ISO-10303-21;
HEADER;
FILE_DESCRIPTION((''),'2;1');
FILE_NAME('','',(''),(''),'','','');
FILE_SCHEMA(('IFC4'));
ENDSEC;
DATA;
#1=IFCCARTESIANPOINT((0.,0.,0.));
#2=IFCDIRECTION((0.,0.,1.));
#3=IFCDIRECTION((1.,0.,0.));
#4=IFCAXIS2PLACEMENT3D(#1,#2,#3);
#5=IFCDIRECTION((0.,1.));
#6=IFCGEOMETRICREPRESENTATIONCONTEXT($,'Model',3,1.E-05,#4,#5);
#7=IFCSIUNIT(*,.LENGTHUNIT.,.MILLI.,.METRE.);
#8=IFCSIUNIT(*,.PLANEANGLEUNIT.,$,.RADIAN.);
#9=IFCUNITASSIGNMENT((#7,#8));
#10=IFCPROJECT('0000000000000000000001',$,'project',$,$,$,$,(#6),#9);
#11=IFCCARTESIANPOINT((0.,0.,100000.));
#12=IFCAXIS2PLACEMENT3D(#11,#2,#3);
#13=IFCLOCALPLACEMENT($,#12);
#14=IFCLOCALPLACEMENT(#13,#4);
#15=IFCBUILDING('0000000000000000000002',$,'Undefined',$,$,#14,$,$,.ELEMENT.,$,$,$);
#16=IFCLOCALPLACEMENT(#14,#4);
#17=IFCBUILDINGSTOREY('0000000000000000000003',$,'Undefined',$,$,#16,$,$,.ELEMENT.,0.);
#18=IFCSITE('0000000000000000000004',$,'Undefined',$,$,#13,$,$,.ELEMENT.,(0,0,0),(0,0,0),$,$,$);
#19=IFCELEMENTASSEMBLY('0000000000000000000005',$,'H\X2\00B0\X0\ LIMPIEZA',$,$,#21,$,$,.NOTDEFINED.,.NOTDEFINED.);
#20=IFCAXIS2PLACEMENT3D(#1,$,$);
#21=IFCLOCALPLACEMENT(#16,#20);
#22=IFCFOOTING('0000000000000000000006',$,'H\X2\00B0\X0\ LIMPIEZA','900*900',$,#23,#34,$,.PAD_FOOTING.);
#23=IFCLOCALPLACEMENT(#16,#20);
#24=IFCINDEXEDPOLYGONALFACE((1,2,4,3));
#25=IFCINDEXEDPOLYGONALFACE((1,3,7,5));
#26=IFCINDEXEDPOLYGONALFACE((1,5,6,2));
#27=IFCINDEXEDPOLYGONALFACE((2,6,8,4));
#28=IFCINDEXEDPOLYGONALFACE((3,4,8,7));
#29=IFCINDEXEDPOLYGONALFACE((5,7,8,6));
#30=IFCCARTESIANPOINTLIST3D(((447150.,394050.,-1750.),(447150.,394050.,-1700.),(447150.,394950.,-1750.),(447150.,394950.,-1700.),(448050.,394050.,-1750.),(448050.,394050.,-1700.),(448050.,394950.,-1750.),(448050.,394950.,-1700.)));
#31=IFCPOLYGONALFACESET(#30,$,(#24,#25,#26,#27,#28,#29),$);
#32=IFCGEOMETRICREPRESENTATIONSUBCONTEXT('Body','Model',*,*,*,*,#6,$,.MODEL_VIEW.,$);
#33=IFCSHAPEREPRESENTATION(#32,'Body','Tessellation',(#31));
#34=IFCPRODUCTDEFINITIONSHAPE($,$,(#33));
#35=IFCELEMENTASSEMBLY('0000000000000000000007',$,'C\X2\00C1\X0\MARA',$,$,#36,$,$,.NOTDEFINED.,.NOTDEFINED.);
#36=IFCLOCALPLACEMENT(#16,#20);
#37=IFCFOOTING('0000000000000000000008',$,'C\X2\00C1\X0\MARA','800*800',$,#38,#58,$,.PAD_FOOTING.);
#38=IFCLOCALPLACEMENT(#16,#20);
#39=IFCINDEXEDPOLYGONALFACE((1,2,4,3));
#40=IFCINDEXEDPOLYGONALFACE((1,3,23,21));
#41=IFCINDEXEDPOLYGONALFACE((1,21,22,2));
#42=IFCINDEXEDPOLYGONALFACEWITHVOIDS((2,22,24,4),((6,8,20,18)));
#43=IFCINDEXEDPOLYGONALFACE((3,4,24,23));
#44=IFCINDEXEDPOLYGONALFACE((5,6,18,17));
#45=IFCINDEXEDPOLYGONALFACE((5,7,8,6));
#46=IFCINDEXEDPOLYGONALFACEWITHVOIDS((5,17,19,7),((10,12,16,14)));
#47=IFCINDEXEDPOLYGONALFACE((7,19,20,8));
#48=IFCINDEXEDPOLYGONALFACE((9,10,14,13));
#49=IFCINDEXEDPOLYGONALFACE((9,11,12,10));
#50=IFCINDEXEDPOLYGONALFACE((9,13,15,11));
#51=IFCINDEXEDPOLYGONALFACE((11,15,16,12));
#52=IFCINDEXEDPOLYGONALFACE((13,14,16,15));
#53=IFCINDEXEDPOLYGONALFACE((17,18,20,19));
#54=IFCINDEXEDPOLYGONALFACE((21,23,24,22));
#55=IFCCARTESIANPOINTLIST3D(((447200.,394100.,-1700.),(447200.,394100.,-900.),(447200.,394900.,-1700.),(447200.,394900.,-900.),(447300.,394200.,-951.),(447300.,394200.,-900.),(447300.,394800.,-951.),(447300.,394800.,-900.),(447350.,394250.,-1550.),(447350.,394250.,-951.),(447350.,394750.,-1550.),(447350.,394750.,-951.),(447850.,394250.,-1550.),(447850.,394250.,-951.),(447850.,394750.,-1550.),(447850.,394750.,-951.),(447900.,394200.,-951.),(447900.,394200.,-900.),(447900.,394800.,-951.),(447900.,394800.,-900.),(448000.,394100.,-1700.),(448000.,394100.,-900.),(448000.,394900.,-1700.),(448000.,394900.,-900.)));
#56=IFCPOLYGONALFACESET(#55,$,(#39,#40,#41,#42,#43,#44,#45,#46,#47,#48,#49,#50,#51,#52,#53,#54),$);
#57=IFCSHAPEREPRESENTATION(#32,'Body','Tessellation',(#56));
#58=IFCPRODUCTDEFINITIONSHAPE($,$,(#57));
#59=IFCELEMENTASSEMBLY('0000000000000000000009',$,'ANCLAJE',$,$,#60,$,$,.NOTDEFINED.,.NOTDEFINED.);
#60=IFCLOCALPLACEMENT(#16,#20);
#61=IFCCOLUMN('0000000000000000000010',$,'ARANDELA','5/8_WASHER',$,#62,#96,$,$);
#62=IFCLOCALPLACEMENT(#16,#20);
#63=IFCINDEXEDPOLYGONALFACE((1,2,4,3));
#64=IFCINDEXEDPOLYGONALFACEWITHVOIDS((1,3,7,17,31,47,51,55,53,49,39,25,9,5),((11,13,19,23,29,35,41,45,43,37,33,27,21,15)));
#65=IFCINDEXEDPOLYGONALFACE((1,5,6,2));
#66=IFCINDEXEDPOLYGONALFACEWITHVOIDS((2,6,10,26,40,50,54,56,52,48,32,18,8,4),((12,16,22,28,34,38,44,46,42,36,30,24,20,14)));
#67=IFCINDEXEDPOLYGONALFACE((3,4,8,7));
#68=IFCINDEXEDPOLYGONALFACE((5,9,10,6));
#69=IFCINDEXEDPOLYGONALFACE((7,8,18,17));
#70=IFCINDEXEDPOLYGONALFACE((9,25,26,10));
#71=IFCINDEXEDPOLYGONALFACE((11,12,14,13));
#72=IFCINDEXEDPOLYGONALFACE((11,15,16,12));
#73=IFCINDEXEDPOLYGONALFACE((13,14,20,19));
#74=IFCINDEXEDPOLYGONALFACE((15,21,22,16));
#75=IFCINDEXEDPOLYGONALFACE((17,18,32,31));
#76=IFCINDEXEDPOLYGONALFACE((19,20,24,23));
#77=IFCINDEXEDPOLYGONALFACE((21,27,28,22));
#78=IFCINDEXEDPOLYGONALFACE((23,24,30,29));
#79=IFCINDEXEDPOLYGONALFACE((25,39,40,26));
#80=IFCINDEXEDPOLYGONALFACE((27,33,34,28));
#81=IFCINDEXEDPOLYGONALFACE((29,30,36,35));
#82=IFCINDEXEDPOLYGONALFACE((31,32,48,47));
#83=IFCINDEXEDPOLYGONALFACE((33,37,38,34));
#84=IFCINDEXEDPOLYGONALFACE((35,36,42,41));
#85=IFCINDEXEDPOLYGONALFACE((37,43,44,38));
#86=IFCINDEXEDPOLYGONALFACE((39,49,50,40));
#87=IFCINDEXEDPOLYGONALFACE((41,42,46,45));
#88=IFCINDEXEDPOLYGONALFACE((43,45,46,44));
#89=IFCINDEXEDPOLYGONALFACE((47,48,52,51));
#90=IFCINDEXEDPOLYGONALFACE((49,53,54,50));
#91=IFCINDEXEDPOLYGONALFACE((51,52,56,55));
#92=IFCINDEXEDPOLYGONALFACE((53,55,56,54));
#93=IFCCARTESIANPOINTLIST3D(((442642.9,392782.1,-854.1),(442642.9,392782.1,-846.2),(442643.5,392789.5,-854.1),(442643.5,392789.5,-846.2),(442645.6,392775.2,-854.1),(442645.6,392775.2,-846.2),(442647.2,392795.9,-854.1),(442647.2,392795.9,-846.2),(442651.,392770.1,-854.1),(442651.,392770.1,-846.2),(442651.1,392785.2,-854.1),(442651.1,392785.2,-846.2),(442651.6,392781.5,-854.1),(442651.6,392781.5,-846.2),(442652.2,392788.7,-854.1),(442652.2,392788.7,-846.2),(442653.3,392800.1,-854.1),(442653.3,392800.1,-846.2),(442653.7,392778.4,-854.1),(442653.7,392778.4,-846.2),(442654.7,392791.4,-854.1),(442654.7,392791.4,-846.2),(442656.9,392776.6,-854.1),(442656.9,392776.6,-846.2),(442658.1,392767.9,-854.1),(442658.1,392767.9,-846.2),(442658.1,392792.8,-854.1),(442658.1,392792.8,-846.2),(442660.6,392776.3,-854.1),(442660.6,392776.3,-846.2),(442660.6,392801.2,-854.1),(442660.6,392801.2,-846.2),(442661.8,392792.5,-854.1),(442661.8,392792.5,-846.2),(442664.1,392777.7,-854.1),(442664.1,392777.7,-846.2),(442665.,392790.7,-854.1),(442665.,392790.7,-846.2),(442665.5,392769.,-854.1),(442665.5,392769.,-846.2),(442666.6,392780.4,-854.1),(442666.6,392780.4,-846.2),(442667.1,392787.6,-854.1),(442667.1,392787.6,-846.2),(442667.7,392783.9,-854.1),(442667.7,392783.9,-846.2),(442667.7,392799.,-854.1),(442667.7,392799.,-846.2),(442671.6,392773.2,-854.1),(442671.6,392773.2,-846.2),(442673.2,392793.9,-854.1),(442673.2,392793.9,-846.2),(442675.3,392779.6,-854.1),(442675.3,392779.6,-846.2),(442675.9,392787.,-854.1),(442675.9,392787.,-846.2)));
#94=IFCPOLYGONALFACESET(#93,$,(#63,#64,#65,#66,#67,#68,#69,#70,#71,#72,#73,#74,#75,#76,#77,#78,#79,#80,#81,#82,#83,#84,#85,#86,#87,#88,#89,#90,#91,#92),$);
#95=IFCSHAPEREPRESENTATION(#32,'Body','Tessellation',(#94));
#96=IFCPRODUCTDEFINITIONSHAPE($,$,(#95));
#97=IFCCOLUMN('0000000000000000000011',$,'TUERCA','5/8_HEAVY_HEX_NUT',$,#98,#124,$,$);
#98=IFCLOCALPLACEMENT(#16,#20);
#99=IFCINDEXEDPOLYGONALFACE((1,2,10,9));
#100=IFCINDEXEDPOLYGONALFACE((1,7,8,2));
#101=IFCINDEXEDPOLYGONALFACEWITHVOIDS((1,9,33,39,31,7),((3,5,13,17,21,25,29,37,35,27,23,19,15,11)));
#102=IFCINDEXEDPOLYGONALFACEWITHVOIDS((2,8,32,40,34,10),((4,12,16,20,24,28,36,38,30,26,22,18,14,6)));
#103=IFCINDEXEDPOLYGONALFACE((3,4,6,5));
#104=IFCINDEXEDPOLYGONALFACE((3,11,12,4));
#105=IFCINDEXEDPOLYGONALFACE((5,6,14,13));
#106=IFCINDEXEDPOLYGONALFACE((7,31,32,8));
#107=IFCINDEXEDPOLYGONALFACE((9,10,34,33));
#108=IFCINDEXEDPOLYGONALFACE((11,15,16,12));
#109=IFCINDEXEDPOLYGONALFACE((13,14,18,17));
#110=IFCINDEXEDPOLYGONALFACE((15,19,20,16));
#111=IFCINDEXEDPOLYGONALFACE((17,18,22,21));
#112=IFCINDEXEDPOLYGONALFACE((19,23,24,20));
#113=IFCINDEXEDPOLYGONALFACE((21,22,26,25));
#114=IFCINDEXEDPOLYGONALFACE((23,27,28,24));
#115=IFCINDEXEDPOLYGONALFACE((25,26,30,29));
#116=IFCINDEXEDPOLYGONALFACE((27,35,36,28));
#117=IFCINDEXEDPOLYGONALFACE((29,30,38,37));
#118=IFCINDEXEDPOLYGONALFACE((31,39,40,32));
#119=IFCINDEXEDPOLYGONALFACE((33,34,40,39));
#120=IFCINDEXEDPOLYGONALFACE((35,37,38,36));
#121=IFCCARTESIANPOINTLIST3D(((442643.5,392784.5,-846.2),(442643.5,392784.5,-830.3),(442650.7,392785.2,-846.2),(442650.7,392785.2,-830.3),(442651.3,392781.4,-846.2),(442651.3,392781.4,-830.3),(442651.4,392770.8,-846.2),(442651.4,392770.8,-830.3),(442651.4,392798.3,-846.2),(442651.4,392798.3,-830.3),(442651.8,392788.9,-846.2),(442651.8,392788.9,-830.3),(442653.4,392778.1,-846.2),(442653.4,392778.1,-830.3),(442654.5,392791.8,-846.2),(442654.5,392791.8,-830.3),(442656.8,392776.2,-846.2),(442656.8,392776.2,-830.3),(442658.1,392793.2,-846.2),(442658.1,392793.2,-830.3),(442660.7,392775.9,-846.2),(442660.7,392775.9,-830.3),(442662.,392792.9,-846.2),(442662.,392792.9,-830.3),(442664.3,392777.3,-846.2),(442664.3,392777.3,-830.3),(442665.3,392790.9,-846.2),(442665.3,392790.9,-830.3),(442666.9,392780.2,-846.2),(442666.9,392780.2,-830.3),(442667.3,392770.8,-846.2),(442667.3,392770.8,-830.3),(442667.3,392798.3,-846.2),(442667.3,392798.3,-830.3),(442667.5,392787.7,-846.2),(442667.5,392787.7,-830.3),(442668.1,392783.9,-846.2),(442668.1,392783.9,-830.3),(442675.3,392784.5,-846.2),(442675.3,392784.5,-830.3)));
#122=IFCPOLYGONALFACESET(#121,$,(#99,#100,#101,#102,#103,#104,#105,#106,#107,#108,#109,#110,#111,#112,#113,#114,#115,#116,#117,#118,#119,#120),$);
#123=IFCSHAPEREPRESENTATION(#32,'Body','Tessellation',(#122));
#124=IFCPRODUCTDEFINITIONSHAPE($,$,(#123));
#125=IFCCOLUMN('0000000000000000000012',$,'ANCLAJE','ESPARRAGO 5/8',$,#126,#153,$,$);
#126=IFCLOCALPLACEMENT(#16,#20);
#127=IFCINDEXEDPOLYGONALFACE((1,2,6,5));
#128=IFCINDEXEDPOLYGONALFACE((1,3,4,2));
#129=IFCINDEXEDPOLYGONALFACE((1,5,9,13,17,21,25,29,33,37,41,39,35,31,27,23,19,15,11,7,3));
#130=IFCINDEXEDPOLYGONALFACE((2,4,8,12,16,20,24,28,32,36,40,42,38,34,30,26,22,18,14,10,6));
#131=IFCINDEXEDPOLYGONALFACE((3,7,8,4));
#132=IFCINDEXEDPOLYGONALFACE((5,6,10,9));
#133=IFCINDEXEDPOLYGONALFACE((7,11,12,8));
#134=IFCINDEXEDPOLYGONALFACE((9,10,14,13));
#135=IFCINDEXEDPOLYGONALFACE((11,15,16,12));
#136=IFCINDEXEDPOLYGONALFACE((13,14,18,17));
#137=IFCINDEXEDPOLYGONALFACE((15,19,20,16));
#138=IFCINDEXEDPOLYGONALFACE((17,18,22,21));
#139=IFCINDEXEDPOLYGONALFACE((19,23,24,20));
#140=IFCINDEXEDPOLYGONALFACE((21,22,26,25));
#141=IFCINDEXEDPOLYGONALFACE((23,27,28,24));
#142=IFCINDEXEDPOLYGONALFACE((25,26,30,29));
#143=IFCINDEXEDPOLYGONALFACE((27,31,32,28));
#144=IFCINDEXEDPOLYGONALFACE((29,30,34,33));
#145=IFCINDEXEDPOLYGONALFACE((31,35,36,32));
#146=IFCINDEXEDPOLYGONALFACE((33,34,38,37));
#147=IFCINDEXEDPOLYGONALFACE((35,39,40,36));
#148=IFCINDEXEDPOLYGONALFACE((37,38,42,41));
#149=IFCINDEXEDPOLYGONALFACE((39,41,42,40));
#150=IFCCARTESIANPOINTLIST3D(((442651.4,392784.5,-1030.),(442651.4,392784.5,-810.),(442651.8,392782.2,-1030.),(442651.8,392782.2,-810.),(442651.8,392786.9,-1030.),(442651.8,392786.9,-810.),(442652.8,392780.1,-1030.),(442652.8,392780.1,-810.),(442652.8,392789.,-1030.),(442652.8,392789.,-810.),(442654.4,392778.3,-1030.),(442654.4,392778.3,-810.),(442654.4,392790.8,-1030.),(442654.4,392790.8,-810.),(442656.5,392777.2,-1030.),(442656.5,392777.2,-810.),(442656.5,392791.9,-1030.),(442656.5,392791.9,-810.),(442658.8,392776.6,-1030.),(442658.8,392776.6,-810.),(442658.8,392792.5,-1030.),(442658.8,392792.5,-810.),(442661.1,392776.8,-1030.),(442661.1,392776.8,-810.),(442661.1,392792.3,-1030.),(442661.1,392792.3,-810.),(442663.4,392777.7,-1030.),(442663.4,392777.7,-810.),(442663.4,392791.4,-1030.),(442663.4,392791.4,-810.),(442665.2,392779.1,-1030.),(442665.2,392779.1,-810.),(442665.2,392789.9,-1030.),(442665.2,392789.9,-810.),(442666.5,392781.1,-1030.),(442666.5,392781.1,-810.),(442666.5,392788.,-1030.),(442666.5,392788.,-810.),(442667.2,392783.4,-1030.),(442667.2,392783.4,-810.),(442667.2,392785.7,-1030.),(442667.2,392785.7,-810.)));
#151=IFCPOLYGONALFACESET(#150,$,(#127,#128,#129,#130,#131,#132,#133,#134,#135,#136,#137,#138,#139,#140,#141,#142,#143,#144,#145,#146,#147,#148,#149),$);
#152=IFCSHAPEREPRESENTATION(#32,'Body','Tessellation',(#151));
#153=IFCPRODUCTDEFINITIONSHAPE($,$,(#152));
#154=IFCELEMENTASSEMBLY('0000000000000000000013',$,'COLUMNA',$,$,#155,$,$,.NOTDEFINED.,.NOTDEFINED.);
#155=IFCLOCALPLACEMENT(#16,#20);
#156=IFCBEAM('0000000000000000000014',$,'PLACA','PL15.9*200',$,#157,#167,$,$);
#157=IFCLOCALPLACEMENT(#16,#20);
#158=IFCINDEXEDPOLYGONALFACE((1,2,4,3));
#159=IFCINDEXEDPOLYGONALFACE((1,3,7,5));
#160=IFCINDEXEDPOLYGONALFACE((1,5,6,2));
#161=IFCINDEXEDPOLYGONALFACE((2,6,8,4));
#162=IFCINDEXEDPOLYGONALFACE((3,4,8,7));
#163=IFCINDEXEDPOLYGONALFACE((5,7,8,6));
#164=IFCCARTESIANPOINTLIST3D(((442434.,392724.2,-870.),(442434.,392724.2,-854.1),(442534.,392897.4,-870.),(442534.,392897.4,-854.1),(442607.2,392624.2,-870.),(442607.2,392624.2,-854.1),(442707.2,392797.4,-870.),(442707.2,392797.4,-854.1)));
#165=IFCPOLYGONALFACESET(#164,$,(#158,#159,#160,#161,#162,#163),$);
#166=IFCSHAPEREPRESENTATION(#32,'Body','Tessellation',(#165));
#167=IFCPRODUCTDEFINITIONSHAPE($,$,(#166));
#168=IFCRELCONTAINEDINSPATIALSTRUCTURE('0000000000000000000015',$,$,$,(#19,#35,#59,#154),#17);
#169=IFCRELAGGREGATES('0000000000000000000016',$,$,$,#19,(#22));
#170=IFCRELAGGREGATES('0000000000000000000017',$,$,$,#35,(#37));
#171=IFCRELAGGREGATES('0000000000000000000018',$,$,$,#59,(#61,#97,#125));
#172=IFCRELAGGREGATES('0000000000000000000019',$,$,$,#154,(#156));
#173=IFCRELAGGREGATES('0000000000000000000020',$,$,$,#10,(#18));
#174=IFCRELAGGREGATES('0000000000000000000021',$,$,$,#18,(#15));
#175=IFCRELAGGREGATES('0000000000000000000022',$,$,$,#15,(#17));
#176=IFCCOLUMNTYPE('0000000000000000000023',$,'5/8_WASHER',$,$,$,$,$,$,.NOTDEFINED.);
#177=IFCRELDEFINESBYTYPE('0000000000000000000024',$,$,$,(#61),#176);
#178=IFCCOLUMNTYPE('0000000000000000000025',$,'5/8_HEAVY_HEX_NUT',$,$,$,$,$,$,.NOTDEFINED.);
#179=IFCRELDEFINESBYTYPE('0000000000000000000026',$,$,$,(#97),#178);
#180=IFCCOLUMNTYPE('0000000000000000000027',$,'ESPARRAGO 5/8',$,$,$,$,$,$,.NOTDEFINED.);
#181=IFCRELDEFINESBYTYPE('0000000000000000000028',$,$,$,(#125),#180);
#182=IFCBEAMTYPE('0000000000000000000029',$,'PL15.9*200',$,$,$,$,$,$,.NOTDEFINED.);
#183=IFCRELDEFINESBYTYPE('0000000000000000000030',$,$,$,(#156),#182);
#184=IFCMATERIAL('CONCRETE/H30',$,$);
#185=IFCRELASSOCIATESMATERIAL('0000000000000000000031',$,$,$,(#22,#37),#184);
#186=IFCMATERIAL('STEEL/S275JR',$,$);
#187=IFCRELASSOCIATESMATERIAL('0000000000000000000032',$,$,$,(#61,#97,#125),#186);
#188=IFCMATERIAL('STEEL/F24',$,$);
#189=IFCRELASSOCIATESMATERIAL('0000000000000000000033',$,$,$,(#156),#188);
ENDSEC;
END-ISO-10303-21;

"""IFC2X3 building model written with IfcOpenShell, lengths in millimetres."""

from ifc_helpers import new_model, si_unit, direction, frame, origin_with_axes, origin_2d_with_axis, place, context, subcontext, project, spatial, polyline, rectangle, circle, outline, extrude, boolean, material, type_object, element, aggregate, save


model = new_model("IFC2X3")

# Units and contexts
model_context = context("Model", 3, precision=1e-05, world=origin_with_axes(), true_north=direction((0.0, 1.0)))
body_context = subcontext(model_context, "Body", "Model", "MODEL_VIEW")
ifc_project = project(units=[si_unit("LENGTHUNIT", "METRE", prefix="MILLI"), si_unit("PLANEANGLEUNIT", "RADIAN")], contexts=[model_context])

# Site, building, storey
site_placement = place(None, frame((0.0, 0.0, 100000.0), z_axis=(0.0, 0.0, 1.0), x_axis=(1.0, 0.0, 0.0)))
site = spatial("IfcSite", under=ifc_project, at=site_placement, Name="Undefined", CompositionType="ELEMENT", RefLatitude=(0, 0, 0), RefLongitude=(0, 0, 0))
building_placement = place(site_placement, origin_with_axes())
building = spatial("IfcBuilding", under=site, at=building_placement, Name="Undefined", CompositionType="ELEMENT")
storey_placement = place(building_placement, origin_with_axes())
storey = spatial("IfcBuildingStorey", under=building, at=storey_placement, Name="Undefined", CompositionType="ELEMENT", Elevation=0.0)

# Element assemblies, footings
assembly_1_placement = place(storey_placement, origin_with_axes())
assembly_1 = element("IfcElementAssembly", 1, at=assembly_1_placement, inside=storey, Name="H° LIMPIEZA", AssemblyPlace="NOTDEFINED", PredefinedType="NOTDEFINED")
ifc_material_1 = material(Name="CONCRETE/H30")
footing_1_placement = place(assembly_1_placement, frame((447600.0, 394500.0, -1750.0), z_axis=(0.0, -1.0, 0.0), x_axis=(0.0, 0.0, 1.0)))
footing_1 = element("IfcFooting", 2, at=footing_1_placement, material=ifc_material_1, Name="H° LIMPIEZA", Description="900*900", PredefinedType="PAD_FOOTING", context=body_context, shape_type="SweptSolid", body=[
    extrude(rectangle(XDim=900.0, YDim=900.0, at=origin_2d_with_axis()), frame((50.0, 0.0, 0.0), z_axis=(-1.0, 0.0, 0.0), x_axis=(0.0, -1.0, 0.0)), (0.0, 0.0, 1.0), 50.0),
])
aggregate(assembly_1, [footing_1])
assembly_2_placement = place(storey_placement, origin_with_axes())
assembly_2 = element("IfcElementAssembly", 3, at=assembly_2_placement, inside=storey, Name="CÁMARA", AssemblyPlace="NOTDEFINED", PredefinedType="NOTDEFINED")
footing_2_placement = place(assembly_2_placement, frame((447600.0, 394500.0, -1700.0), z_axis=(0.0, -1.0, 0.0), x_axis=(0.0, 0.0, 1.0)))
footing_2 = element("IfcFooting", 4, at=footing_2_placement, material=ifc_material_1, Name="CÁMARA", Description="800*800", PredefinedType="PAD_FOOTING", context=body_context, shape_type="CSG", body=[
    boolean("DIFFERENCE", boolean("DIFFERENCE", extrude(rectangle(XDim=800.0, YDim=800.0, at=origin_2d_with_axis()), frame((800.0, 0.0, 0.0), z_axis=(-1.0, 0.0, 0.0), x_axis=(0.0, -1.0, 0.0)), (0.0, 0.0, 1.0), 800.0), extrude(rectangle(XDim=600.0, YDim=600.0, at=origin_2d_with_axis()), frame((800.0, 0.0, 0.0), z_axis=(-1.0, 0.0, 0.0), x_axis=(0.0, -1.0, 0.0)), (0.0, 0.0, 1.0), 51.0)), extrude(rectangle(XDim=500.0, YDim=500.0, at=origin_2d_with_axis()), frame((750.0, 0.0, 0.0), z_axis=(-1.0, 0.0, 0.0), x_axis=(0.0, -1.0, 0.0)), (0.0, 0.0, 1.0), 600.0)),
])
aggregate(assembly_2, [footing_2])

# Element assembly, columns
assembly_3_placement = place(storey_placement, origin_with_axes())
assembly_3 = element("IfcElementAssembly", 5, at=assembly_3_placement, inside=storey, Name="ANCLAJE", AssemblyPlace="NOTDEFINED", PredefinedType="NOTDEFINED")
ifc_material_2 = material(Name="STEEL/S275JR")
column_type_1 = type_object("IfcColumnType", Name="5/8_WASHER", PredefinedType="NOTDEFINED")
column_1_placement = place(assembly_3_placement, frame((442659.4, 392784.5, -846.2), z_axis=(0.0, 0.0, -1.0), x_axis=(-0.866025, 0.5, 0.0)))
column_1 = element("IfcColumn", 6, at=column_1_placement, type_object=column_type_1, material=ifc_material_2, Name="ARANDELA", Description="5/8_WASHER", context=body_context, shape_type="SweptSolid", body=[
    extrude(outline(polyline([(10.4, 13.0), (15.0, 7.2), (16.7, 0.0), (15.0, -7.2), (10.4, -13.0), (3.7, -16.3), (-3.7, -16.3), (-10.4, -13.0), (-15.0, -7.2), (-16.7, 0.0), (-15.0, 7.2), (-10.4, 13.0), (-3.7, 16.3), (3.7, 16.3), (10.4, 13.0)]), holes=[polyline([(6.5, -5.2), (8.1, -1.9), (8.1, 1.9), (6.5, 5.2), (3.6, 7.5), (0.0, 8.3), (-3.6, 7.5), (-6.5, 5.2), (-8.1, 1.9), (-8.1, -1.9), (-6.5, -5.2), (-3.6, -7.5), (0.0, -8.3), (3.6, -7.5), (6.5, -5.2)])]), frame((0.0, 0.0, 7.9), z_axis=(0.0, 0.0, -1.0), x_axis=(0.0, 1.0, 0.0)), (0.0, 0.0, 1.0), 7.9),
])
column_type_2 = type_object("IfcColumnType", Name="5/8_HEAVY_HEX_NUT", PredefinedType="NOTDEFINED")
column_2_placement = place(assembly_3_placement, frame((442659.4, 392784.5, -830.3), z_axis=(0.0, 0.0, -1.0), x_axis=(-0.866025, 0.5, 0.0)))
column_2 = element("IfcColumn", 7, at=column_2_placement, type_object=column_type_2, material=ifc_material_2, Name="TUERCA", Description="5/8_HEAVY_HEX_NUT", context=body_context, shape_type="SweptSolid", body=[
    extrude(outline(polyline([(-7.9, -13.7), (-15.9, 0.0), (-7.9, 13.7), (7.9, 13.7), (15.9, 0.0), (7.9, -13.7), (-7.9, -13.7)]), holes=[polyline([(3.8, 7.9), (0.0, 8.7), (-3.8, 7.9), (-6.8, 5.4), (-8.5, 1.9), (-8.5, -1.9), (-6.8, -5.4), (-3.8, -7.9), (0.0, -8.7), (3.8, -7.9), (6.8, -5.4), (8.5, -1.9), (8.5, 1.9), (6.8, 5.4), (3.8, 7.9)])]), frame((0.0, 0.0, 15.9), z_axis=(0.0, 0.0, -1.0), x_axis=(0.0, 1.0, 0.0)), (0.0, 0.0, 1.0), 15.9),
])
column_type_3 = type_object("IfcColumnType", Name="ESPARRAGO 5/8", PredefinedType="NOTDEFINED")
column_3_placement = place(assembly_3_placement, frame((442659.4, 392784.5, -810.0), z_axis=(0.0, 0.0, -1.0), x_axis=(-0.866025, 0.5, 0.0)))
column_3 = element("IfcColumn", 8, at=column_3_placement, type_object=column_type_3, material=ifc_material_2, Name="ANCLAJE", Description="ESPARRAGO 5/8", context=body_context, shape_type="SweptSolid", body=[
    extrude(circle(Radius=7.9, at=origin_2d_with_axis()), frame((0.0, 0.0, 220.0), z_axis=(0.0, 0.0, -1.0), x_axis=(0.0, 1.0, 0.0)), (0.0, 0.0, 1.0), 220.0),
])
aggregate(assembly_3, [column_1, column_2, column_3])

# Element assembly, beam
assembly_4_placement = place(storey_placement, origin_with_axes())
assembly_4 = element("IfcElementAssembly", 9, at=assembly_4_placement, inside=storey, Name="COLUMNA", AssemblyPlace="NOTDEFINED", PredefinedType="NOTDEFINED")
ifc_material_3 = material(Name="STEEL/F24")
beam_type = type_object("IfcBeamType", Name="PL15.9*200", PredefinedType="NOTDEFINED")
beam_placement = place(assembly_4_placement, frame((442657.2, 392710.8, -862.1), z_axis=(-0.5, -0.866025, 0.0), x_axis=(-0.866025, 0.5, 0.0)))
beam = element("IfcBeam", 10, at=beam_placement, type_object=beam_type, material=ifc_material_3, Name="PLACA", Description="PL15.9*200", context=body_context, shape_type="SweptSolid", body=[
    extrude(rectangle(XDim=15.9, YDim=200.0, at=origin_2d_with_axis()), frame((200.0, 0.0, 0.0), z_axis=(-1.0, 0.0, 0.0), x_axis=(0.0, -1.0, 0.0)), (0.0, 0.0, 1.0), 200.0),
])
aggregate(assembly_4, [beam])

save(model, "model.ifc")
